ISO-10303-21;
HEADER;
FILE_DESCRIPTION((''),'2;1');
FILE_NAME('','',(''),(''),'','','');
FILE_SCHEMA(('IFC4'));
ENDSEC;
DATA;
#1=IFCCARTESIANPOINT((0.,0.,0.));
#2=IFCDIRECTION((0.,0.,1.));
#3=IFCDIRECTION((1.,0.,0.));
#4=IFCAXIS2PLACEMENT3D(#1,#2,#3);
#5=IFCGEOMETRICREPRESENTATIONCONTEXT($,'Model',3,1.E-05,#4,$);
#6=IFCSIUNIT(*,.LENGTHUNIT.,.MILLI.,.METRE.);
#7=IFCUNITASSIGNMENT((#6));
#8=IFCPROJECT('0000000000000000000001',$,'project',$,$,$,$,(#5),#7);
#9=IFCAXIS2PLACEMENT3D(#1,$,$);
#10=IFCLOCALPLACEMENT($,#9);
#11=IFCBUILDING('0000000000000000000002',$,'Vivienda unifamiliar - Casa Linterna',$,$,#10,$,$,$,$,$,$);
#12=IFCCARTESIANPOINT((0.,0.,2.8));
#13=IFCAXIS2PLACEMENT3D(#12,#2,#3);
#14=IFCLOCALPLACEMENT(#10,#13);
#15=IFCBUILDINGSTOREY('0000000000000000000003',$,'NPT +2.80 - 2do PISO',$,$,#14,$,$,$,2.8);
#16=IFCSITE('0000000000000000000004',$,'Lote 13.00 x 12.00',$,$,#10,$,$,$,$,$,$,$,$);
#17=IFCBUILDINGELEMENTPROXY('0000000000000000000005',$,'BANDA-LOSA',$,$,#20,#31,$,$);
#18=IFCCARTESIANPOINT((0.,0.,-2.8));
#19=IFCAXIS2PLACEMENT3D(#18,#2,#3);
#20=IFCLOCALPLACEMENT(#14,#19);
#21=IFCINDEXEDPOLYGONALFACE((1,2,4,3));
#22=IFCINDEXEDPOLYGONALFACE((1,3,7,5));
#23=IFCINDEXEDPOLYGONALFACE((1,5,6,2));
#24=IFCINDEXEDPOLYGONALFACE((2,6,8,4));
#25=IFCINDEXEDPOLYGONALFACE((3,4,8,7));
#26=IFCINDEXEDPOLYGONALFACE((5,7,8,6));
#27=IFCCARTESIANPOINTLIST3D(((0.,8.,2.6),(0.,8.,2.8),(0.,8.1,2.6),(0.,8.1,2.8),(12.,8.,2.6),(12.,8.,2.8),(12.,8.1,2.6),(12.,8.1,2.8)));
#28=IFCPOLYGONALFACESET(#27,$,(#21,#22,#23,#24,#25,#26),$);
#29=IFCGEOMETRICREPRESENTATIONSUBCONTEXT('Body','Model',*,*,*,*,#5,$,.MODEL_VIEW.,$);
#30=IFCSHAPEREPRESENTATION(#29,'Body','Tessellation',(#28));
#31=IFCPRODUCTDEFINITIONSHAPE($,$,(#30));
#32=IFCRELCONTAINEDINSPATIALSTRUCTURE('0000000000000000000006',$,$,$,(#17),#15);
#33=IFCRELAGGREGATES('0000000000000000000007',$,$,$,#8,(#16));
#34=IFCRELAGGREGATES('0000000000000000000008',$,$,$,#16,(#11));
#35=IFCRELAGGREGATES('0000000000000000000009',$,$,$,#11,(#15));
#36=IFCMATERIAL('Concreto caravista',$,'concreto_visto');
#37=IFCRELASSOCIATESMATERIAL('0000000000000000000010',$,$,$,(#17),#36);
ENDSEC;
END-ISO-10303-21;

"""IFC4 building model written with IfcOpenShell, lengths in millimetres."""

from ifc_helpers import new_model, si_unit, frame, origin, origin_with_axes, place, context, subcontext, project, spatial, polyline, outline, extrude, material, element, save


model = new_model("IFC4")

# Units and contexts
model_context = context("Model", 3, precision=1e-05, world=origin_with_axes())
body_context = subcontext(model_context, "Body", "Model", "MODEL_VIEW")
ifc_project = project(units=[si_unit("LENGTHUNIT", "METRE", prefix="MILLI")], contexts=[model_context])

# Site, building, storey
placement = place(None, origin())
site = spatial("IfcSite", under=ifc_project, at=placement, Name="Lote 13.00 x 12.00")
building = spatial("IfcBuilding", under=site, at=placement, Name="Vivienda unifamiliar - Casa Linterna")
storey_placement = place(placement, frame((0.0, 0.0, 2.8), z_axis=(0.0, 0.0, 1.0), x_axis=(1.0, 0.0, 0.0)))
storey = spatial("IfcBuildingStorey", under=building, at=storey_placement, Name="NPT +2.80 - 2do PISO", Elevation=2.8)

# Building element proxy
ifc_material_1 = material(Name="Concreto caravista", Category="concreto_visto")
proxy_placement = place(storey_placement, frame((0.0, 0.0, -2.8), z_axis=(0.0, 0.0, 1.0), x_axis=(1.0, 0.0, 0.0)))
element("IfcBuildingElementProxy", 1, at=proxy_placement, inside=storey, material=ifc_material_1, Name="BANDA-LOSA", context=body_context, shape_type="SweptSolid", body=[
    extrude(outline(polyline([(8.0, 2.6), (8.1, 2.6), (8.1, 2.8), (8.0, 2.8), (8.0, 2.6)])), frame((0.0, 0.0, 0.0), z_axis=(1.0, 0.0, 0.0), x_axis=(0.0, 1.0, 0.0)), (0.0, 0.0, 1.0), 12.0),
])

save(model, "model.ifc")
